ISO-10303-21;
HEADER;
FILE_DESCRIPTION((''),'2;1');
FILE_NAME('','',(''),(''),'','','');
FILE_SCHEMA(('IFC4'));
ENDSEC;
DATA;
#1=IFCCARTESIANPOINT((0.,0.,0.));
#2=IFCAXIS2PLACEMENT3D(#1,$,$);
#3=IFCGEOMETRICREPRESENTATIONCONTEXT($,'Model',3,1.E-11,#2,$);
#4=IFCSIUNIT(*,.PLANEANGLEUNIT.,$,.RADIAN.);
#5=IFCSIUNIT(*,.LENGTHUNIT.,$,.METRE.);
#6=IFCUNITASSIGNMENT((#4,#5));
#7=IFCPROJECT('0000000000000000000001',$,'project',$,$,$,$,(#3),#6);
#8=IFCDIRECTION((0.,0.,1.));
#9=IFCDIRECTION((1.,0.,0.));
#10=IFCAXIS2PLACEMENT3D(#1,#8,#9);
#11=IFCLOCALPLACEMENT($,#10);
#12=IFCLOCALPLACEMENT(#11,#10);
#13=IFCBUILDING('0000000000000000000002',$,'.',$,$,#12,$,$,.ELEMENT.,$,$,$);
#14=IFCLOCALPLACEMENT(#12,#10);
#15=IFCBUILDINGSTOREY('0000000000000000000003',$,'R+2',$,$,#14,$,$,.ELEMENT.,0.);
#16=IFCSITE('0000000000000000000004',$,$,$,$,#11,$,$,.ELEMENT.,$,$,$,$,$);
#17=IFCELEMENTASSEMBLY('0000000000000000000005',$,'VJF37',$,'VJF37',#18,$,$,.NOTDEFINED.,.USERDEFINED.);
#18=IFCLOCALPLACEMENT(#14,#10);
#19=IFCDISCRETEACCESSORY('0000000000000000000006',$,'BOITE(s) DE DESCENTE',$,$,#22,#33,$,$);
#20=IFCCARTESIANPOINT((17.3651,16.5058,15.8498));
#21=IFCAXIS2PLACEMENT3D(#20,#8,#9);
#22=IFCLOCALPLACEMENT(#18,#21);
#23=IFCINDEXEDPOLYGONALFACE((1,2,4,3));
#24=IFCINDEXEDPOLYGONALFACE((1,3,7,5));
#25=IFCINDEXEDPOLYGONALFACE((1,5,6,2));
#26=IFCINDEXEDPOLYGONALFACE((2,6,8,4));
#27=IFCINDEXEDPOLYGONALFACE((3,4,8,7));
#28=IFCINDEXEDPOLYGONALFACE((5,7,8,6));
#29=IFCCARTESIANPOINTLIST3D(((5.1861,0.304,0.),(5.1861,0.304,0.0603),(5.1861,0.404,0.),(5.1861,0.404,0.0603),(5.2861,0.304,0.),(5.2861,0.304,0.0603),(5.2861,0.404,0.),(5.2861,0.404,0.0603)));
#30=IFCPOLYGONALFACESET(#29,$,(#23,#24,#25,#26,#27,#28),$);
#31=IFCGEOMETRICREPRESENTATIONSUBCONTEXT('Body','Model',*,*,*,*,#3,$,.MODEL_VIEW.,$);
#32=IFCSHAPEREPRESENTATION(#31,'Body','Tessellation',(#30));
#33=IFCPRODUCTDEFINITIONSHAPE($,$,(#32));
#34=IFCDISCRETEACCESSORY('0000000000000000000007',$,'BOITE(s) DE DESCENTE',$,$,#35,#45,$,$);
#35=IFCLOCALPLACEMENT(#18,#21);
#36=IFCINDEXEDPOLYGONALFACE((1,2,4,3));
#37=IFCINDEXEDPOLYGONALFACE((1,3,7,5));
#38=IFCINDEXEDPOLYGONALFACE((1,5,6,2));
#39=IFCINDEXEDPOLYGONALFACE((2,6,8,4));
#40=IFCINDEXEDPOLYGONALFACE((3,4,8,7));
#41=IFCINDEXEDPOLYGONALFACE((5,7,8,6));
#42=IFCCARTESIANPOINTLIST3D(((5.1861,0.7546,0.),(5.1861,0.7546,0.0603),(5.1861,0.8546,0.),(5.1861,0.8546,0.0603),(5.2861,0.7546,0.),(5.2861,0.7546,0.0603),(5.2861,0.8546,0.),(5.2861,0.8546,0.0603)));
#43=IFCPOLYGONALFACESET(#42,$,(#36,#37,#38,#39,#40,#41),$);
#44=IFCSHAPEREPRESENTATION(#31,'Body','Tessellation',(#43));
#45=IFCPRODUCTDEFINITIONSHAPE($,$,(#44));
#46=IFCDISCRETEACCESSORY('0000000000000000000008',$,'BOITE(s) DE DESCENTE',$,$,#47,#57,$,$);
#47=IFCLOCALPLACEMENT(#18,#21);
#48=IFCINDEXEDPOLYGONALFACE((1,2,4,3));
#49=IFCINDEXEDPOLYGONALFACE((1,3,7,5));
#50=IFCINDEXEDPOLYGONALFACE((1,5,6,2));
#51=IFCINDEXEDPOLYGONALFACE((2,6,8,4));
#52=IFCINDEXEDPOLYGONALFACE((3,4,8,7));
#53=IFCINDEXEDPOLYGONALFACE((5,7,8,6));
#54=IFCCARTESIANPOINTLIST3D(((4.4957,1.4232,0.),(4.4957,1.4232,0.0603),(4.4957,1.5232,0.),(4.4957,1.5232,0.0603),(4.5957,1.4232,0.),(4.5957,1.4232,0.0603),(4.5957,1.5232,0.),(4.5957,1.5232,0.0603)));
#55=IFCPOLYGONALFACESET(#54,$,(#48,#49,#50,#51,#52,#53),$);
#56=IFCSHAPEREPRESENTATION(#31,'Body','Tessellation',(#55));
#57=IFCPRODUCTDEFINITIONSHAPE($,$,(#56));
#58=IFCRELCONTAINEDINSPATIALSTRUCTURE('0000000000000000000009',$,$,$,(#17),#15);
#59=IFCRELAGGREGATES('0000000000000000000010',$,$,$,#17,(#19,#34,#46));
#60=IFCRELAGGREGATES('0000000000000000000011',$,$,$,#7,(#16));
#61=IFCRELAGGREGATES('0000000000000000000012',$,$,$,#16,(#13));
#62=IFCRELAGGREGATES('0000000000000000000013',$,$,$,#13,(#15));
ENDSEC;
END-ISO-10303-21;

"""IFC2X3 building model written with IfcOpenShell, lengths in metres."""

from ifc_helpers import new_model, si_unit, frame, origin, origin_with_axes, place, context, subcontext, project, spatial, polyline, outline, extrude, element, aggregate, save


model = new_model("IFC2X3")

# Units and contexts
model_context = context("Model", 3, precision=1e-11, world=origin())
body_context = subcontext(model_context, "Body", "Model", "MODEL_VIEW")
ifc_project = project(units=[si_unit("PLANEANGLEUNIT", "RADIAN"), si_unit("LENGTHUNIT", "METRE")], contexts=[model_context])

# Site, building, storey
site_placement = place(None, origin_with_axes())
site = spatial("IfcSite", under=ifc_project, at=site_placement, CompositionType="ELEMENT")
building_placement = place(site_placement, origin_with_axes())
building = spatial("IfcBuilding", under=site, at=building_placement, Name=".", CompositionType="ELEMENT")
storey_placement = place(building_placement, origin_with_axes())
storey = spatial("IfcBuildingStorey", under=building, at=storey_placement, Name="R+2", CompositionType="ELEMENT", Elevation=0.0)

# Element assembly, discrete accessories
assembly_placement = place(storey_placement, origin_with_axes())
assembly = element("IfcElementAssembly", 1, at=assembly_placement, inside=storey, Name="VJF37", ObjectType="VJF37", AssemblyPlace="NOTDEFINED", PredefinedType="USERDEFINED")
discrete_accessory_1_placement = place(assembly_placement, frame((17.3651, 16.5058, 15.8498), z_axis=(0.0, 0.0, 1.0), x_axis=(1.0, 0.0, 0.0)))
discrete_accessory_1 = element("IfcDiscreteAccessory", 2, at=discrete_accessory_1_placement, Name="BOITE(s) DE DESCENTE", context=body_context, shape_type="SweptSolid", body=[
    extrude(outline(polyline([(0.304, -5.1861), (0.304, -5.2861), (0.404, -5.2861), (0.404, -5.1861), (0.304, -5.1861)])), frame((0.0, 0.0, 0.0), z_axis=(0.0, 0.0, 1.0), x_axis=(0.0, 1.0, 0.0)), (0.0, 0.0, 1.0), 0.0603),
])
discrete_accessory_2_placement = place(assembly_placement, frame((17.3651, 16.5058, 15.8498), z_axis=(0.0, 0.0, 1.0), x_axis=(1.0, 0.0, 0.0)))
discrete_accessory_2 = element("IfcDiscreteAccessory", 3, at=discrete_accessory_2_placement, Name="BOITE(s) DE DESCENTE", context=body_context, shape_type="SweptSolid", body=[
    extrude(outline(polyline([(0.7546, -5.1861), (0.7546, -5.2861), (0.8546, -5.2861), (0.8546, -5.1861), (0.7546, -5.1861)])), frame((0.0, 0.0, 0.0), z_axis=(0.0, 0.0, 1.0), x_axis=(0.0, 1.0, 0.0)), (0.0, 0.0, 1.0), 0.0603),
])
discrete_accessory_3_placement = place(assembly_placement, frame((17.3651, 16.5058, 15.8498), z_axis=(0.0, 0.0, 1.0), x_axis=(1.0, 0.0, 0.0)))
discrete_accessory_3 = element("IfcDiscreteAccessory", 4, at=discrete_accessory_3_placement, Name="BOITE(s) DE DESCENTE", context=body_context, shape_type="SweptSolid", body=[
    extrude(outline(polyline([(1.4232, -4.4957), (1.4232, -4.5957), (1.5232, -4.5957), (1.5232, -4.4957), (1.4232, -4.4957)])), frame((0.0, 0.0, 0.0), z_axis=(0.0, 0.0, 1.0), x_axis=(0.0, 1.0, 0.0)), (0.0, 0.0, 1.0), 0.0603),
])
aggregate(assembly, [discrete_accessory_1, discrete_accessory_2, discrete_accessory_3])

save(model, "model.ifc")
